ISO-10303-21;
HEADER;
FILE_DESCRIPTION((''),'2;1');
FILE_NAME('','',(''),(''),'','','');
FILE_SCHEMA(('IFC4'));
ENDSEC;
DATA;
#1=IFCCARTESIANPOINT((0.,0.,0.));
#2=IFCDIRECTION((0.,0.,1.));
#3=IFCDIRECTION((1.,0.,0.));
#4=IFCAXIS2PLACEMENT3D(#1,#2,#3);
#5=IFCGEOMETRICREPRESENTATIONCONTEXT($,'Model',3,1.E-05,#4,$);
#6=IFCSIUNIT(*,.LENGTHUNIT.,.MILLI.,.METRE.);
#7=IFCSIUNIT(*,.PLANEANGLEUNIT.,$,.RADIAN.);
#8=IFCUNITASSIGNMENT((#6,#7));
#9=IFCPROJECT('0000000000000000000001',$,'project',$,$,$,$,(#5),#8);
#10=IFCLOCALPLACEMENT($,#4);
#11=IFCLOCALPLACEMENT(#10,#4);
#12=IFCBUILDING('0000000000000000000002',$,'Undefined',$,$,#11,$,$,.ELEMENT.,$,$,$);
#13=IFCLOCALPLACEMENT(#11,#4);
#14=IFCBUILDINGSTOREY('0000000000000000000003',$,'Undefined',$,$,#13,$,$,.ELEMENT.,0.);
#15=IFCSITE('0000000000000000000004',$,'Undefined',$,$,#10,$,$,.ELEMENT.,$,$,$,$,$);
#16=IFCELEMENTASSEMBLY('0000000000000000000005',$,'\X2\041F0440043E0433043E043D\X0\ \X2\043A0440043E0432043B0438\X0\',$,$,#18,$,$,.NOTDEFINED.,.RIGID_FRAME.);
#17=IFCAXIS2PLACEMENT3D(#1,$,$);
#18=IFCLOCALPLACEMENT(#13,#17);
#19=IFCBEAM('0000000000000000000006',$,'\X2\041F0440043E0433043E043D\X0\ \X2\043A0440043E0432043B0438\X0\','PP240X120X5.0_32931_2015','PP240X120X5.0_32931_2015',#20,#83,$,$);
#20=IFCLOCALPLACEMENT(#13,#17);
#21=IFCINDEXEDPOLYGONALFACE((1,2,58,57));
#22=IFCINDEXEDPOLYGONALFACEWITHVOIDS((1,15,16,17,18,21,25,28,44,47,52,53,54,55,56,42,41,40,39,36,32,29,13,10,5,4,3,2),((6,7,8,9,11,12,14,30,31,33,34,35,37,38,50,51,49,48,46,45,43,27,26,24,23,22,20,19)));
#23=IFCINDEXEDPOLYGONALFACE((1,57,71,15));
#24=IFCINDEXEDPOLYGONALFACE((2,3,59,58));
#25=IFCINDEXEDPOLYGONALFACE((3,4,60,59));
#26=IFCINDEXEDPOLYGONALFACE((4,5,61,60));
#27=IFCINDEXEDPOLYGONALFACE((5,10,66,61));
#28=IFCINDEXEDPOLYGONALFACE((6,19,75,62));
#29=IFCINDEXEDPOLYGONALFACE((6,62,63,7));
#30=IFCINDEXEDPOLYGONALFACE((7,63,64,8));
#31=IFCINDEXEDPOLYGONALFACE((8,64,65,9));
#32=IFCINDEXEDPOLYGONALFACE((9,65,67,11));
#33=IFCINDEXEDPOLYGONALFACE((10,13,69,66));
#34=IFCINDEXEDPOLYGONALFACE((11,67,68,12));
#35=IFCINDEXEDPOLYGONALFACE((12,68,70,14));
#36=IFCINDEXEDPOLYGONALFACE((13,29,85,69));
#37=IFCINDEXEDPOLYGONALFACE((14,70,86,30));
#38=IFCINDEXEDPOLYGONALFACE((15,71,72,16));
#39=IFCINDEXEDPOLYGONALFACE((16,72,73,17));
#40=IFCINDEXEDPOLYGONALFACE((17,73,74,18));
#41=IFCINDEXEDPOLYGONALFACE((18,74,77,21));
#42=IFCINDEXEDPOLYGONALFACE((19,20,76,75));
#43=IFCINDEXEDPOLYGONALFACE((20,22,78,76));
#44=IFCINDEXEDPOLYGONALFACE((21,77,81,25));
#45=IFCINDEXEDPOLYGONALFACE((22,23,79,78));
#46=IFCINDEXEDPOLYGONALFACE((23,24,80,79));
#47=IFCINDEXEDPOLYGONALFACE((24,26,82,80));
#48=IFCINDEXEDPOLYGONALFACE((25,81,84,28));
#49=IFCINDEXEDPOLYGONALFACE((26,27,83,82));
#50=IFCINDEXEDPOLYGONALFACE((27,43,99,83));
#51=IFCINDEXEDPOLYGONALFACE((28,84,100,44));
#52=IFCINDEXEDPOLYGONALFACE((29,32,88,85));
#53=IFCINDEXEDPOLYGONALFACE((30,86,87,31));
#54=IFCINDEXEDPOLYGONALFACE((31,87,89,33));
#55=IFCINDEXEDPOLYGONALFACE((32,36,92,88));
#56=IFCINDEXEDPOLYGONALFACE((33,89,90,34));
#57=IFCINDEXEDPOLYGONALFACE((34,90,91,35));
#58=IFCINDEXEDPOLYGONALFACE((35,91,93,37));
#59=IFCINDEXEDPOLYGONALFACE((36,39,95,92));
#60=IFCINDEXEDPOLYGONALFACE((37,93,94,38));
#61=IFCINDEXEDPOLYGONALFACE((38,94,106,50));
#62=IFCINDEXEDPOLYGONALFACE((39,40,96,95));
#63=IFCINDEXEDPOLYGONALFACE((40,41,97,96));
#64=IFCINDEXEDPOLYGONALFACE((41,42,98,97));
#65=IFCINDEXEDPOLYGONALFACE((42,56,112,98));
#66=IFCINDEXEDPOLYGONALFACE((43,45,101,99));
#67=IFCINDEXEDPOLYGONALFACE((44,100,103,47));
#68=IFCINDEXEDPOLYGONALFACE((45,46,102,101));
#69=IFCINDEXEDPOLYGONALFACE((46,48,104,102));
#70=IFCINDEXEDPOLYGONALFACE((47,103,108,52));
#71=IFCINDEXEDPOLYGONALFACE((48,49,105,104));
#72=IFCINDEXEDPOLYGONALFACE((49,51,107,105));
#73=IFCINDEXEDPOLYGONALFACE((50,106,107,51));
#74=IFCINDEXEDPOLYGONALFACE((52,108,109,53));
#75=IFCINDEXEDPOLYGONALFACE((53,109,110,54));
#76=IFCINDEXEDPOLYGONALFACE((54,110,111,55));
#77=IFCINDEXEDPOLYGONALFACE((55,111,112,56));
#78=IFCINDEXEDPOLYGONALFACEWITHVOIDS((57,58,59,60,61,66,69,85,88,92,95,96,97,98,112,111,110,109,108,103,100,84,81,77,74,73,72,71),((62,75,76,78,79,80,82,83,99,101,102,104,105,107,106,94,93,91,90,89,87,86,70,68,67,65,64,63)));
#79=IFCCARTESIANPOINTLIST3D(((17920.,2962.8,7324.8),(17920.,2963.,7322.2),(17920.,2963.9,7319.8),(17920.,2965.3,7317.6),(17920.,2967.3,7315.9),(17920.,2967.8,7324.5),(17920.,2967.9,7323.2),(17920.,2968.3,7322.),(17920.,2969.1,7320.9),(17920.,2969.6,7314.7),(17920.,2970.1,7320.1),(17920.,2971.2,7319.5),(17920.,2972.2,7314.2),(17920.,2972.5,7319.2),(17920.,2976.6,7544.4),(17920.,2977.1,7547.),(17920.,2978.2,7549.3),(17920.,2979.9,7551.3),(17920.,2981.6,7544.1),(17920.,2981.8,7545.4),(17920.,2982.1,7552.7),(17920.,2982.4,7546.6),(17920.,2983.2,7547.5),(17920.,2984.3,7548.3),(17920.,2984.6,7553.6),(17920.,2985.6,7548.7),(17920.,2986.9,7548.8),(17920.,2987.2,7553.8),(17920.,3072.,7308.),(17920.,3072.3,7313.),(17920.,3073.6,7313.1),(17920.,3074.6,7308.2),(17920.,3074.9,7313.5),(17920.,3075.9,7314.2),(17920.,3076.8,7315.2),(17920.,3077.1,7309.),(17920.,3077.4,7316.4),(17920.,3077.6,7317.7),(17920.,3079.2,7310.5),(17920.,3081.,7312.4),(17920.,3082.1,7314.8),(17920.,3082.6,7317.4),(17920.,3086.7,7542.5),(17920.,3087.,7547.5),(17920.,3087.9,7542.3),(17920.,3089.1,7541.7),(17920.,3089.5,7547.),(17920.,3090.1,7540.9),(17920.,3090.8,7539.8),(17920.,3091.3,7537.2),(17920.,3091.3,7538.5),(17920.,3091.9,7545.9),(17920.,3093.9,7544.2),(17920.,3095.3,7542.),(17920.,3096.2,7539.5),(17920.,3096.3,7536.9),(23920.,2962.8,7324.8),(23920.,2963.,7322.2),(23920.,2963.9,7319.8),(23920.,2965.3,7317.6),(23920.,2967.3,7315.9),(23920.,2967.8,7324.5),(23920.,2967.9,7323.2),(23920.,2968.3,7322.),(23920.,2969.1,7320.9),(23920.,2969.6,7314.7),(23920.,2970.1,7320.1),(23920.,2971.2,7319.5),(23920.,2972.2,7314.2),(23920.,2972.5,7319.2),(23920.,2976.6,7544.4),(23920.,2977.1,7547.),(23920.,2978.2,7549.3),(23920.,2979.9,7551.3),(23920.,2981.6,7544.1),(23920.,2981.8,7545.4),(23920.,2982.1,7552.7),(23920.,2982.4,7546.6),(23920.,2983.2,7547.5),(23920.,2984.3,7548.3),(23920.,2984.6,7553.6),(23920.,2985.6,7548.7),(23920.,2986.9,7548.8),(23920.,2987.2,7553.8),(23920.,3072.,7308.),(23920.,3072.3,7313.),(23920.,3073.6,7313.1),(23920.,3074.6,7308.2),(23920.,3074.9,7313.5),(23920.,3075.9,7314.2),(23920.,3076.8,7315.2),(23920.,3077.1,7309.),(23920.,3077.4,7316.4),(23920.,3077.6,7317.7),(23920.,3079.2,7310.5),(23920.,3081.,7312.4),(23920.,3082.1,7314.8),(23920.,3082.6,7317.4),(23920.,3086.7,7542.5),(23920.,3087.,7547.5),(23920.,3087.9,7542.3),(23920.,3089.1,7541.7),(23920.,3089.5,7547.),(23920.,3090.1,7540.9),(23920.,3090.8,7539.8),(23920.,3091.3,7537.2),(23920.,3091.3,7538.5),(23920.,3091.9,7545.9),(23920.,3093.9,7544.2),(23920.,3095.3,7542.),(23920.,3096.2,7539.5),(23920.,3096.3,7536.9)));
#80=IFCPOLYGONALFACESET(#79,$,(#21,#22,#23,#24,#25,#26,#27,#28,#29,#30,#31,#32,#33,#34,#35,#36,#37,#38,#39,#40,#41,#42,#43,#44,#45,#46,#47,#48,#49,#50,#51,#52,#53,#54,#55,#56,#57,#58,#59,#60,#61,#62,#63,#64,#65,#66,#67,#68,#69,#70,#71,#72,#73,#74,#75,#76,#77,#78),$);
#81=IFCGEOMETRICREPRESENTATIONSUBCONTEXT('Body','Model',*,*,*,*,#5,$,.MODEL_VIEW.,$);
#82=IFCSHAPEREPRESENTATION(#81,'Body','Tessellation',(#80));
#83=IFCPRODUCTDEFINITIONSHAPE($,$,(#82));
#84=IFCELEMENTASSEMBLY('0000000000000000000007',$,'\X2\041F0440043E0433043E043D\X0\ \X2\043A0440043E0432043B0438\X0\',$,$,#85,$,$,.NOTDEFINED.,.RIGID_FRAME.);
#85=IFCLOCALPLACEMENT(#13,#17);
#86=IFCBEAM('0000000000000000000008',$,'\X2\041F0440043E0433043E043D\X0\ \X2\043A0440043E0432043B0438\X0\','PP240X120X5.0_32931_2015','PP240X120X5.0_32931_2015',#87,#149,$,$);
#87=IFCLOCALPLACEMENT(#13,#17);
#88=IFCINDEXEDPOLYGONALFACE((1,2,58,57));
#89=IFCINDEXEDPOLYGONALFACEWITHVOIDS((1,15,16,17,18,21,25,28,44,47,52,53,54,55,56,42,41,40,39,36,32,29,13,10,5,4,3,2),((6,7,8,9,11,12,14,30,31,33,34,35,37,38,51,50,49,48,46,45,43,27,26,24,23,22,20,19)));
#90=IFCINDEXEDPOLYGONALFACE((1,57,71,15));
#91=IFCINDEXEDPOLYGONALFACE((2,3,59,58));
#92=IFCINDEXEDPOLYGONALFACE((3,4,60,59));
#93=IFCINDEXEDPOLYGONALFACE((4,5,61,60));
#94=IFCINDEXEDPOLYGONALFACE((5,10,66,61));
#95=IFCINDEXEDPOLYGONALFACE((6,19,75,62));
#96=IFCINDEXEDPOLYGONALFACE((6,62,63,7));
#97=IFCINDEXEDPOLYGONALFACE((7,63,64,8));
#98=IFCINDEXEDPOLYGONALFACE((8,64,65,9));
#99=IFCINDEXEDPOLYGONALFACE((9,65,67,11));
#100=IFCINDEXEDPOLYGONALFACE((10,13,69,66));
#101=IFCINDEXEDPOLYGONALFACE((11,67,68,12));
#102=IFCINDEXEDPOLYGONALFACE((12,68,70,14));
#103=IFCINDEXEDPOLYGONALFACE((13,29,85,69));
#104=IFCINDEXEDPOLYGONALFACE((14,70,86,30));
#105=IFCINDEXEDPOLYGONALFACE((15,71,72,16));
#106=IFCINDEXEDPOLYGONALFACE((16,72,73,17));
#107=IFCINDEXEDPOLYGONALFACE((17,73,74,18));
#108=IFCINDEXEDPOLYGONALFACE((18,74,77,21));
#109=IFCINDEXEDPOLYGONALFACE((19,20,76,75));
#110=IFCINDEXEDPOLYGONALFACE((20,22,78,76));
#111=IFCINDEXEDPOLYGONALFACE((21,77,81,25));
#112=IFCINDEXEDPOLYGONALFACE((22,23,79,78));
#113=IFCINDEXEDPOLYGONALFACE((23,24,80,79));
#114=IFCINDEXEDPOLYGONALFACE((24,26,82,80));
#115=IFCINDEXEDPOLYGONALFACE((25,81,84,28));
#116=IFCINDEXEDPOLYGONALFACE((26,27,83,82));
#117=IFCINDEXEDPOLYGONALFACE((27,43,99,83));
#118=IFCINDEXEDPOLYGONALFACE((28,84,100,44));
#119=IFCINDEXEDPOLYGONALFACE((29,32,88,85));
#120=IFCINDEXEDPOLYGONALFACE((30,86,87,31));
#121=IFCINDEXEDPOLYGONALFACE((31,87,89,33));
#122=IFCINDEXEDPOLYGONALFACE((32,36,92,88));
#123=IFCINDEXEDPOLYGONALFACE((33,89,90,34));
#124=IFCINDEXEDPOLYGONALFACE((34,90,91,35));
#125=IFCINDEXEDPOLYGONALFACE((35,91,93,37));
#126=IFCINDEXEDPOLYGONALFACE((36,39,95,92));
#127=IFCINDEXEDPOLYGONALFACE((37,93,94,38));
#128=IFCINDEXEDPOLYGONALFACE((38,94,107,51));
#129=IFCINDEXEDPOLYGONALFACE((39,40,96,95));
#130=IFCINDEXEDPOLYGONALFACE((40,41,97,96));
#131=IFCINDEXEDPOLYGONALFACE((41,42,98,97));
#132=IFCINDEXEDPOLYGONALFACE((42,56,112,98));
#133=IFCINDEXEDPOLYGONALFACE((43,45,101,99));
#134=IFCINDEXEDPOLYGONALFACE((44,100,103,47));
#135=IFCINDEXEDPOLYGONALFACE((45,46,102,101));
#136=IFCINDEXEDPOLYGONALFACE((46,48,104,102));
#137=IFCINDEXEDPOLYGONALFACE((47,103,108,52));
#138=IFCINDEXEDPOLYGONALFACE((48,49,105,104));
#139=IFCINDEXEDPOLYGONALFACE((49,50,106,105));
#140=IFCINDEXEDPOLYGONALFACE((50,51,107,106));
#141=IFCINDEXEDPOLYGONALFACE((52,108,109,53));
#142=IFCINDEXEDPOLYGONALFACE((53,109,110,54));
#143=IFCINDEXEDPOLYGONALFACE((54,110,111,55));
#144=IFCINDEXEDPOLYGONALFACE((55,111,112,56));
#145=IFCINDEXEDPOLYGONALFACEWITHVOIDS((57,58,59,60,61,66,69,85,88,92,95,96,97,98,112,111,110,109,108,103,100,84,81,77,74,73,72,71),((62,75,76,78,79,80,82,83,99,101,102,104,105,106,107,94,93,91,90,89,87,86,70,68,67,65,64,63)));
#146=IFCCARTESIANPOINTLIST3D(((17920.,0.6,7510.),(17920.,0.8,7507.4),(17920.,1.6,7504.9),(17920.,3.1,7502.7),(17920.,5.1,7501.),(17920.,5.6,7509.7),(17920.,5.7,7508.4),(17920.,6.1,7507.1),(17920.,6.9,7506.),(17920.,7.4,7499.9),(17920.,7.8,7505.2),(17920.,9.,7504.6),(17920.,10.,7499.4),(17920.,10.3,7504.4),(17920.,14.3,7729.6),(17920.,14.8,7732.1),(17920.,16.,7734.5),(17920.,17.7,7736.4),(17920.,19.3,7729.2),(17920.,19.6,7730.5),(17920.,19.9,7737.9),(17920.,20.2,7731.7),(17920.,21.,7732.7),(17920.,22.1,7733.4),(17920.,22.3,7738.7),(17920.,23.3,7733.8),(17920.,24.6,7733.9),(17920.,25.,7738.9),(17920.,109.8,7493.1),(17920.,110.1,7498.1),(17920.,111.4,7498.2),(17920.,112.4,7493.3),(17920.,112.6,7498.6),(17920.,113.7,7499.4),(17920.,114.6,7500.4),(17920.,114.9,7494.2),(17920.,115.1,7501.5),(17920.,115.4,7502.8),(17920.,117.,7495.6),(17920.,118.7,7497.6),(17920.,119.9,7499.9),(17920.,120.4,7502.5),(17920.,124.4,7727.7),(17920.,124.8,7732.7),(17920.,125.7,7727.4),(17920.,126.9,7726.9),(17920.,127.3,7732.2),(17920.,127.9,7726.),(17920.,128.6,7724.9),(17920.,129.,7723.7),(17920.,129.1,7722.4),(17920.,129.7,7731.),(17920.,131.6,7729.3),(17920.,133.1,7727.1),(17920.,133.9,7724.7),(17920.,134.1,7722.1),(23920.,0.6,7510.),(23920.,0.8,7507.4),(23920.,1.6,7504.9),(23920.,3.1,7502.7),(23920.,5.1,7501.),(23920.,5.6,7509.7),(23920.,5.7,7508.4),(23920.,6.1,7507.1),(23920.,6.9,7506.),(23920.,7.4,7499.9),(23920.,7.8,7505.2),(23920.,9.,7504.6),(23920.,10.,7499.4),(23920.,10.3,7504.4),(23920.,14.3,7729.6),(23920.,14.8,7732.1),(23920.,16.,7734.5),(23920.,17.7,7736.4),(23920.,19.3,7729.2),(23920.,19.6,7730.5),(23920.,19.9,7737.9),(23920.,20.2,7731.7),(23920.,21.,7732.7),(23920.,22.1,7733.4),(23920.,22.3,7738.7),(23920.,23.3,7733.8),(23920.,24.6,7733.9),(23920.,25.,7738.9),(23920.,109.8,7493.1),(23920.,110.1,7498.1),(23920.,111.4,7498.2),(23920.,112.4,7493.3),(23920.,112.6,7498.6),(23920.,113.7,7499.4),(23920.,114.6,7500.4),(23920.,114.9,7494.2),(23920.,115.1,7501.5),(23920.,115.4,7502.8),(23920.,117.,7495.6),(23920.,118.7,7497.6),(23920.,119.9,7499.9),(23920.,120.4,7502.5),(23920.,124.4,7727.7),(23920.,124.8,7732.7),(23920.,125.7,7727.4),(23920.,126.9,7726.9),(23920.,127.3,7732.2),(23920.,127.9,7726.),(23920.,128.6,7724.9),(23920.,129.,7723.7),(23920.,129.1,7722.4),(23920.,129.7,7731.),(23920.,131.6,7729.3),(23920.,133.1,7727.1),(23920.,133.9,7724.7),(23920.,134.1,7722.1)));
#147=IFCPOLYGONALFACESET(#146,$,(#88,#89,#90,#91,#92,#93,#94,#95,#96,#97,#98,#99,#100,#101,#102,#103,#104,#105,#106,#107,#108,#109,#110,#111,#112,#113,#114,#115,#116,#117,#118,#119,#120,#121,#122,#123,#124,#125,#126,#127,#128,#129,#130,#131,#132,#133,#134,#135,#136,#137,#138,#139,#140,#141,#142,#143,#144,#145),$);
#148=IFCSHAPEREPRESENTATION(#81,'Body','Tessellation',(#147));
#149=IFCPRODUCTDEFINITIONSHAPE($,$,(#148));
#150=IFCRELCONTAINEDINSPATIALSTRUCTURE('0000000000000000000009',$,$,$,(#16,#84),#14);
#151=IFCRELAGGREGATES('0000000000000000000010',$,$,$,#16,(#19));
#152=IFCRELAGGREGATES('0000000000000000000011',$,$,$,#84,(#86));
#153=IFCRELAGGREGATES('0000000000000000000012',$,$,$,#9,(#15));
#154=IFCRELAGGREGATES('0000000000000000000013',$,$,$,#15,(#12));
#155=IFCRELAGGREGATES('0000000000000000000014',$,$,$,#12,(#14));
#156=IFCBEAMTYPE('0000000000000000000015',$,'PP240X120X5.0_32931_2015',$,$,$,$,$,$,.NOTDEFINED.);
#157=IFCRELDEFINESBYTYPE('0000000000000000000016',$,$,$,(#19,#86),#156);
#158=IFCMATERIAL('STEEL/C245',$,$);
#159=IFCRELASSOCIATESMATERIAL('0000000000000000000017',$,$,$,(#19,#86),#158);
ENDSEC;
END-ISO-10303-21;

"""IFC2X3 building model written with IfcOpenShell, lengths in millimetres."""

from ifc_helpers import new_model, si_unit, frame, origin_with_axes, origin_2d_with_axis, place, context, subcontext, project, spatial, hollow_rectangle, extrude, material, type_object, element, aggregate, save


model = new_model("IFC2X3")

# Units and contexts
model_context = context("Model", 3, precision=1e-05, world=origin_with_axes())
body_context = subcontext(model_context, "Body", "Model", "MODEL_VIEW")
ifc_project = project(units=[si_unit("LENGTHUNIT", "METRE", prefix="MILLI"), si_unit("PLANEANGLEUNIT", "RADIAN")], contexts=[model_context])

# Site, building, storey
site_placement = place(None, origin_with_axes())
site = spatial("IfcSite", under=ifc_project, at=site_placement, Name="Undefined", CompositionType="ELEMENT")
building_placement = place(site_placement, origin_with_axes())
building = spatial("IfcBuilding", under=site, at=building_placement, Name="Undefined", CompositionType="ELEMENT")
storey_placement = place(building_placement, origin_with_axes())
storey = spatial("IfcBuildingStorey", under=building, at=storey_placement, Name="Undefined", CompositionType="ELEMENT", Elevation=0.0)

# Shared definitions
ifc_material = material(Name="STEEL/C245")

# Element assemblies, beams
beam_type_1 = type_object("IfcBeamType", Name="PP240X120X5.0_32931_2015", PredefinedType="NOTDEFINED")
assembly_1_placement = place(storey_placement, origin_with_axes())
assembly_1 = element("IfcElementAssembly", 1, at=assembly_1_placement, inside=storey, Name="Прогон кровли", AssemblyPlace="NOTDEFINED", PredefinedType="RIGID_FRAME")
beam_1_placement = place(assembly_1_placement, frame((23920.0, 3029.6, 7430.9), z_axis=(0.0, 0.062378, 0.998053), x_axis=(-1.0, 0.0, 0.0)))
beam_1 = element("IfcBeam", 2, at=beam_1_placement, type_object=beam_type_1, material=ifc_material, Name="Прогон кровли", Description="PP240X120X5.0_32931_2015", ObjectType="PP240X120X5.0_32931_2015", context=body_context, shape_type="SweptSolid", body=[
    extrude(hollow_rectangle(XDim=120.0, YDim=240.0, WallThickness=5.0, InnerFilletRadius=5.0, OuterFilletRadius=10.0, at=origin_2d_with_axis()), frame((6000.0, 0.0, 0.0), z_axis=(-1.0, 0.0, 0.0), x_axis=(0.0, -1.0, 0.0)), (0.0, 0.0, 1.0), 6000.0),
])
aggregate(assembly_1, [beam_1])
assembly_2_placement = place(storey_placement, origin_with_axes())
assembly_2 = element("IfcElementAssembly", 3, at=assembly_2_placement, inside=storey, Name="Прогон кровли", AssemblyPlace="NOTDEFINED", PredefinedType="RIGID_FRAME")
beam_2_placement = place(assembly_2_placement, frame((23920.0, 67.4, 7616.0), z_axis=(0.0, 0.062378, 0.998053), x_axis=(-1.0, 0.0, 0.0)))
beam_2 = element("IfcBeam", 4, at=beam_2_placement, type_object=beam_type_1, material=ifc_material, Name="Прогон кровли", Description="PP240X120X5.0_32931_2015", ObjectType="PP240X120X5.0_32931_2015", context=body_context, shape_type="SweptSolid", body=[
    extrude(hollow_rectangle(XDim=120.0, YDim=240.0, WallThickness=5.0, InnerFilletRadius=5.0, OuterFilletRadius=10.0, at=origin_2d_with_axis()), frame((6000.0, 0.0, 0.0), z_axis=(-1.0, 0.0, 0.0), x_axis=(0.0, -1.0, 0.0)), (0.0, 0.0, 1.0), 6000.0),
])
aggregate(assembly_2, [beam_2])

save(model, "model.ifc")
